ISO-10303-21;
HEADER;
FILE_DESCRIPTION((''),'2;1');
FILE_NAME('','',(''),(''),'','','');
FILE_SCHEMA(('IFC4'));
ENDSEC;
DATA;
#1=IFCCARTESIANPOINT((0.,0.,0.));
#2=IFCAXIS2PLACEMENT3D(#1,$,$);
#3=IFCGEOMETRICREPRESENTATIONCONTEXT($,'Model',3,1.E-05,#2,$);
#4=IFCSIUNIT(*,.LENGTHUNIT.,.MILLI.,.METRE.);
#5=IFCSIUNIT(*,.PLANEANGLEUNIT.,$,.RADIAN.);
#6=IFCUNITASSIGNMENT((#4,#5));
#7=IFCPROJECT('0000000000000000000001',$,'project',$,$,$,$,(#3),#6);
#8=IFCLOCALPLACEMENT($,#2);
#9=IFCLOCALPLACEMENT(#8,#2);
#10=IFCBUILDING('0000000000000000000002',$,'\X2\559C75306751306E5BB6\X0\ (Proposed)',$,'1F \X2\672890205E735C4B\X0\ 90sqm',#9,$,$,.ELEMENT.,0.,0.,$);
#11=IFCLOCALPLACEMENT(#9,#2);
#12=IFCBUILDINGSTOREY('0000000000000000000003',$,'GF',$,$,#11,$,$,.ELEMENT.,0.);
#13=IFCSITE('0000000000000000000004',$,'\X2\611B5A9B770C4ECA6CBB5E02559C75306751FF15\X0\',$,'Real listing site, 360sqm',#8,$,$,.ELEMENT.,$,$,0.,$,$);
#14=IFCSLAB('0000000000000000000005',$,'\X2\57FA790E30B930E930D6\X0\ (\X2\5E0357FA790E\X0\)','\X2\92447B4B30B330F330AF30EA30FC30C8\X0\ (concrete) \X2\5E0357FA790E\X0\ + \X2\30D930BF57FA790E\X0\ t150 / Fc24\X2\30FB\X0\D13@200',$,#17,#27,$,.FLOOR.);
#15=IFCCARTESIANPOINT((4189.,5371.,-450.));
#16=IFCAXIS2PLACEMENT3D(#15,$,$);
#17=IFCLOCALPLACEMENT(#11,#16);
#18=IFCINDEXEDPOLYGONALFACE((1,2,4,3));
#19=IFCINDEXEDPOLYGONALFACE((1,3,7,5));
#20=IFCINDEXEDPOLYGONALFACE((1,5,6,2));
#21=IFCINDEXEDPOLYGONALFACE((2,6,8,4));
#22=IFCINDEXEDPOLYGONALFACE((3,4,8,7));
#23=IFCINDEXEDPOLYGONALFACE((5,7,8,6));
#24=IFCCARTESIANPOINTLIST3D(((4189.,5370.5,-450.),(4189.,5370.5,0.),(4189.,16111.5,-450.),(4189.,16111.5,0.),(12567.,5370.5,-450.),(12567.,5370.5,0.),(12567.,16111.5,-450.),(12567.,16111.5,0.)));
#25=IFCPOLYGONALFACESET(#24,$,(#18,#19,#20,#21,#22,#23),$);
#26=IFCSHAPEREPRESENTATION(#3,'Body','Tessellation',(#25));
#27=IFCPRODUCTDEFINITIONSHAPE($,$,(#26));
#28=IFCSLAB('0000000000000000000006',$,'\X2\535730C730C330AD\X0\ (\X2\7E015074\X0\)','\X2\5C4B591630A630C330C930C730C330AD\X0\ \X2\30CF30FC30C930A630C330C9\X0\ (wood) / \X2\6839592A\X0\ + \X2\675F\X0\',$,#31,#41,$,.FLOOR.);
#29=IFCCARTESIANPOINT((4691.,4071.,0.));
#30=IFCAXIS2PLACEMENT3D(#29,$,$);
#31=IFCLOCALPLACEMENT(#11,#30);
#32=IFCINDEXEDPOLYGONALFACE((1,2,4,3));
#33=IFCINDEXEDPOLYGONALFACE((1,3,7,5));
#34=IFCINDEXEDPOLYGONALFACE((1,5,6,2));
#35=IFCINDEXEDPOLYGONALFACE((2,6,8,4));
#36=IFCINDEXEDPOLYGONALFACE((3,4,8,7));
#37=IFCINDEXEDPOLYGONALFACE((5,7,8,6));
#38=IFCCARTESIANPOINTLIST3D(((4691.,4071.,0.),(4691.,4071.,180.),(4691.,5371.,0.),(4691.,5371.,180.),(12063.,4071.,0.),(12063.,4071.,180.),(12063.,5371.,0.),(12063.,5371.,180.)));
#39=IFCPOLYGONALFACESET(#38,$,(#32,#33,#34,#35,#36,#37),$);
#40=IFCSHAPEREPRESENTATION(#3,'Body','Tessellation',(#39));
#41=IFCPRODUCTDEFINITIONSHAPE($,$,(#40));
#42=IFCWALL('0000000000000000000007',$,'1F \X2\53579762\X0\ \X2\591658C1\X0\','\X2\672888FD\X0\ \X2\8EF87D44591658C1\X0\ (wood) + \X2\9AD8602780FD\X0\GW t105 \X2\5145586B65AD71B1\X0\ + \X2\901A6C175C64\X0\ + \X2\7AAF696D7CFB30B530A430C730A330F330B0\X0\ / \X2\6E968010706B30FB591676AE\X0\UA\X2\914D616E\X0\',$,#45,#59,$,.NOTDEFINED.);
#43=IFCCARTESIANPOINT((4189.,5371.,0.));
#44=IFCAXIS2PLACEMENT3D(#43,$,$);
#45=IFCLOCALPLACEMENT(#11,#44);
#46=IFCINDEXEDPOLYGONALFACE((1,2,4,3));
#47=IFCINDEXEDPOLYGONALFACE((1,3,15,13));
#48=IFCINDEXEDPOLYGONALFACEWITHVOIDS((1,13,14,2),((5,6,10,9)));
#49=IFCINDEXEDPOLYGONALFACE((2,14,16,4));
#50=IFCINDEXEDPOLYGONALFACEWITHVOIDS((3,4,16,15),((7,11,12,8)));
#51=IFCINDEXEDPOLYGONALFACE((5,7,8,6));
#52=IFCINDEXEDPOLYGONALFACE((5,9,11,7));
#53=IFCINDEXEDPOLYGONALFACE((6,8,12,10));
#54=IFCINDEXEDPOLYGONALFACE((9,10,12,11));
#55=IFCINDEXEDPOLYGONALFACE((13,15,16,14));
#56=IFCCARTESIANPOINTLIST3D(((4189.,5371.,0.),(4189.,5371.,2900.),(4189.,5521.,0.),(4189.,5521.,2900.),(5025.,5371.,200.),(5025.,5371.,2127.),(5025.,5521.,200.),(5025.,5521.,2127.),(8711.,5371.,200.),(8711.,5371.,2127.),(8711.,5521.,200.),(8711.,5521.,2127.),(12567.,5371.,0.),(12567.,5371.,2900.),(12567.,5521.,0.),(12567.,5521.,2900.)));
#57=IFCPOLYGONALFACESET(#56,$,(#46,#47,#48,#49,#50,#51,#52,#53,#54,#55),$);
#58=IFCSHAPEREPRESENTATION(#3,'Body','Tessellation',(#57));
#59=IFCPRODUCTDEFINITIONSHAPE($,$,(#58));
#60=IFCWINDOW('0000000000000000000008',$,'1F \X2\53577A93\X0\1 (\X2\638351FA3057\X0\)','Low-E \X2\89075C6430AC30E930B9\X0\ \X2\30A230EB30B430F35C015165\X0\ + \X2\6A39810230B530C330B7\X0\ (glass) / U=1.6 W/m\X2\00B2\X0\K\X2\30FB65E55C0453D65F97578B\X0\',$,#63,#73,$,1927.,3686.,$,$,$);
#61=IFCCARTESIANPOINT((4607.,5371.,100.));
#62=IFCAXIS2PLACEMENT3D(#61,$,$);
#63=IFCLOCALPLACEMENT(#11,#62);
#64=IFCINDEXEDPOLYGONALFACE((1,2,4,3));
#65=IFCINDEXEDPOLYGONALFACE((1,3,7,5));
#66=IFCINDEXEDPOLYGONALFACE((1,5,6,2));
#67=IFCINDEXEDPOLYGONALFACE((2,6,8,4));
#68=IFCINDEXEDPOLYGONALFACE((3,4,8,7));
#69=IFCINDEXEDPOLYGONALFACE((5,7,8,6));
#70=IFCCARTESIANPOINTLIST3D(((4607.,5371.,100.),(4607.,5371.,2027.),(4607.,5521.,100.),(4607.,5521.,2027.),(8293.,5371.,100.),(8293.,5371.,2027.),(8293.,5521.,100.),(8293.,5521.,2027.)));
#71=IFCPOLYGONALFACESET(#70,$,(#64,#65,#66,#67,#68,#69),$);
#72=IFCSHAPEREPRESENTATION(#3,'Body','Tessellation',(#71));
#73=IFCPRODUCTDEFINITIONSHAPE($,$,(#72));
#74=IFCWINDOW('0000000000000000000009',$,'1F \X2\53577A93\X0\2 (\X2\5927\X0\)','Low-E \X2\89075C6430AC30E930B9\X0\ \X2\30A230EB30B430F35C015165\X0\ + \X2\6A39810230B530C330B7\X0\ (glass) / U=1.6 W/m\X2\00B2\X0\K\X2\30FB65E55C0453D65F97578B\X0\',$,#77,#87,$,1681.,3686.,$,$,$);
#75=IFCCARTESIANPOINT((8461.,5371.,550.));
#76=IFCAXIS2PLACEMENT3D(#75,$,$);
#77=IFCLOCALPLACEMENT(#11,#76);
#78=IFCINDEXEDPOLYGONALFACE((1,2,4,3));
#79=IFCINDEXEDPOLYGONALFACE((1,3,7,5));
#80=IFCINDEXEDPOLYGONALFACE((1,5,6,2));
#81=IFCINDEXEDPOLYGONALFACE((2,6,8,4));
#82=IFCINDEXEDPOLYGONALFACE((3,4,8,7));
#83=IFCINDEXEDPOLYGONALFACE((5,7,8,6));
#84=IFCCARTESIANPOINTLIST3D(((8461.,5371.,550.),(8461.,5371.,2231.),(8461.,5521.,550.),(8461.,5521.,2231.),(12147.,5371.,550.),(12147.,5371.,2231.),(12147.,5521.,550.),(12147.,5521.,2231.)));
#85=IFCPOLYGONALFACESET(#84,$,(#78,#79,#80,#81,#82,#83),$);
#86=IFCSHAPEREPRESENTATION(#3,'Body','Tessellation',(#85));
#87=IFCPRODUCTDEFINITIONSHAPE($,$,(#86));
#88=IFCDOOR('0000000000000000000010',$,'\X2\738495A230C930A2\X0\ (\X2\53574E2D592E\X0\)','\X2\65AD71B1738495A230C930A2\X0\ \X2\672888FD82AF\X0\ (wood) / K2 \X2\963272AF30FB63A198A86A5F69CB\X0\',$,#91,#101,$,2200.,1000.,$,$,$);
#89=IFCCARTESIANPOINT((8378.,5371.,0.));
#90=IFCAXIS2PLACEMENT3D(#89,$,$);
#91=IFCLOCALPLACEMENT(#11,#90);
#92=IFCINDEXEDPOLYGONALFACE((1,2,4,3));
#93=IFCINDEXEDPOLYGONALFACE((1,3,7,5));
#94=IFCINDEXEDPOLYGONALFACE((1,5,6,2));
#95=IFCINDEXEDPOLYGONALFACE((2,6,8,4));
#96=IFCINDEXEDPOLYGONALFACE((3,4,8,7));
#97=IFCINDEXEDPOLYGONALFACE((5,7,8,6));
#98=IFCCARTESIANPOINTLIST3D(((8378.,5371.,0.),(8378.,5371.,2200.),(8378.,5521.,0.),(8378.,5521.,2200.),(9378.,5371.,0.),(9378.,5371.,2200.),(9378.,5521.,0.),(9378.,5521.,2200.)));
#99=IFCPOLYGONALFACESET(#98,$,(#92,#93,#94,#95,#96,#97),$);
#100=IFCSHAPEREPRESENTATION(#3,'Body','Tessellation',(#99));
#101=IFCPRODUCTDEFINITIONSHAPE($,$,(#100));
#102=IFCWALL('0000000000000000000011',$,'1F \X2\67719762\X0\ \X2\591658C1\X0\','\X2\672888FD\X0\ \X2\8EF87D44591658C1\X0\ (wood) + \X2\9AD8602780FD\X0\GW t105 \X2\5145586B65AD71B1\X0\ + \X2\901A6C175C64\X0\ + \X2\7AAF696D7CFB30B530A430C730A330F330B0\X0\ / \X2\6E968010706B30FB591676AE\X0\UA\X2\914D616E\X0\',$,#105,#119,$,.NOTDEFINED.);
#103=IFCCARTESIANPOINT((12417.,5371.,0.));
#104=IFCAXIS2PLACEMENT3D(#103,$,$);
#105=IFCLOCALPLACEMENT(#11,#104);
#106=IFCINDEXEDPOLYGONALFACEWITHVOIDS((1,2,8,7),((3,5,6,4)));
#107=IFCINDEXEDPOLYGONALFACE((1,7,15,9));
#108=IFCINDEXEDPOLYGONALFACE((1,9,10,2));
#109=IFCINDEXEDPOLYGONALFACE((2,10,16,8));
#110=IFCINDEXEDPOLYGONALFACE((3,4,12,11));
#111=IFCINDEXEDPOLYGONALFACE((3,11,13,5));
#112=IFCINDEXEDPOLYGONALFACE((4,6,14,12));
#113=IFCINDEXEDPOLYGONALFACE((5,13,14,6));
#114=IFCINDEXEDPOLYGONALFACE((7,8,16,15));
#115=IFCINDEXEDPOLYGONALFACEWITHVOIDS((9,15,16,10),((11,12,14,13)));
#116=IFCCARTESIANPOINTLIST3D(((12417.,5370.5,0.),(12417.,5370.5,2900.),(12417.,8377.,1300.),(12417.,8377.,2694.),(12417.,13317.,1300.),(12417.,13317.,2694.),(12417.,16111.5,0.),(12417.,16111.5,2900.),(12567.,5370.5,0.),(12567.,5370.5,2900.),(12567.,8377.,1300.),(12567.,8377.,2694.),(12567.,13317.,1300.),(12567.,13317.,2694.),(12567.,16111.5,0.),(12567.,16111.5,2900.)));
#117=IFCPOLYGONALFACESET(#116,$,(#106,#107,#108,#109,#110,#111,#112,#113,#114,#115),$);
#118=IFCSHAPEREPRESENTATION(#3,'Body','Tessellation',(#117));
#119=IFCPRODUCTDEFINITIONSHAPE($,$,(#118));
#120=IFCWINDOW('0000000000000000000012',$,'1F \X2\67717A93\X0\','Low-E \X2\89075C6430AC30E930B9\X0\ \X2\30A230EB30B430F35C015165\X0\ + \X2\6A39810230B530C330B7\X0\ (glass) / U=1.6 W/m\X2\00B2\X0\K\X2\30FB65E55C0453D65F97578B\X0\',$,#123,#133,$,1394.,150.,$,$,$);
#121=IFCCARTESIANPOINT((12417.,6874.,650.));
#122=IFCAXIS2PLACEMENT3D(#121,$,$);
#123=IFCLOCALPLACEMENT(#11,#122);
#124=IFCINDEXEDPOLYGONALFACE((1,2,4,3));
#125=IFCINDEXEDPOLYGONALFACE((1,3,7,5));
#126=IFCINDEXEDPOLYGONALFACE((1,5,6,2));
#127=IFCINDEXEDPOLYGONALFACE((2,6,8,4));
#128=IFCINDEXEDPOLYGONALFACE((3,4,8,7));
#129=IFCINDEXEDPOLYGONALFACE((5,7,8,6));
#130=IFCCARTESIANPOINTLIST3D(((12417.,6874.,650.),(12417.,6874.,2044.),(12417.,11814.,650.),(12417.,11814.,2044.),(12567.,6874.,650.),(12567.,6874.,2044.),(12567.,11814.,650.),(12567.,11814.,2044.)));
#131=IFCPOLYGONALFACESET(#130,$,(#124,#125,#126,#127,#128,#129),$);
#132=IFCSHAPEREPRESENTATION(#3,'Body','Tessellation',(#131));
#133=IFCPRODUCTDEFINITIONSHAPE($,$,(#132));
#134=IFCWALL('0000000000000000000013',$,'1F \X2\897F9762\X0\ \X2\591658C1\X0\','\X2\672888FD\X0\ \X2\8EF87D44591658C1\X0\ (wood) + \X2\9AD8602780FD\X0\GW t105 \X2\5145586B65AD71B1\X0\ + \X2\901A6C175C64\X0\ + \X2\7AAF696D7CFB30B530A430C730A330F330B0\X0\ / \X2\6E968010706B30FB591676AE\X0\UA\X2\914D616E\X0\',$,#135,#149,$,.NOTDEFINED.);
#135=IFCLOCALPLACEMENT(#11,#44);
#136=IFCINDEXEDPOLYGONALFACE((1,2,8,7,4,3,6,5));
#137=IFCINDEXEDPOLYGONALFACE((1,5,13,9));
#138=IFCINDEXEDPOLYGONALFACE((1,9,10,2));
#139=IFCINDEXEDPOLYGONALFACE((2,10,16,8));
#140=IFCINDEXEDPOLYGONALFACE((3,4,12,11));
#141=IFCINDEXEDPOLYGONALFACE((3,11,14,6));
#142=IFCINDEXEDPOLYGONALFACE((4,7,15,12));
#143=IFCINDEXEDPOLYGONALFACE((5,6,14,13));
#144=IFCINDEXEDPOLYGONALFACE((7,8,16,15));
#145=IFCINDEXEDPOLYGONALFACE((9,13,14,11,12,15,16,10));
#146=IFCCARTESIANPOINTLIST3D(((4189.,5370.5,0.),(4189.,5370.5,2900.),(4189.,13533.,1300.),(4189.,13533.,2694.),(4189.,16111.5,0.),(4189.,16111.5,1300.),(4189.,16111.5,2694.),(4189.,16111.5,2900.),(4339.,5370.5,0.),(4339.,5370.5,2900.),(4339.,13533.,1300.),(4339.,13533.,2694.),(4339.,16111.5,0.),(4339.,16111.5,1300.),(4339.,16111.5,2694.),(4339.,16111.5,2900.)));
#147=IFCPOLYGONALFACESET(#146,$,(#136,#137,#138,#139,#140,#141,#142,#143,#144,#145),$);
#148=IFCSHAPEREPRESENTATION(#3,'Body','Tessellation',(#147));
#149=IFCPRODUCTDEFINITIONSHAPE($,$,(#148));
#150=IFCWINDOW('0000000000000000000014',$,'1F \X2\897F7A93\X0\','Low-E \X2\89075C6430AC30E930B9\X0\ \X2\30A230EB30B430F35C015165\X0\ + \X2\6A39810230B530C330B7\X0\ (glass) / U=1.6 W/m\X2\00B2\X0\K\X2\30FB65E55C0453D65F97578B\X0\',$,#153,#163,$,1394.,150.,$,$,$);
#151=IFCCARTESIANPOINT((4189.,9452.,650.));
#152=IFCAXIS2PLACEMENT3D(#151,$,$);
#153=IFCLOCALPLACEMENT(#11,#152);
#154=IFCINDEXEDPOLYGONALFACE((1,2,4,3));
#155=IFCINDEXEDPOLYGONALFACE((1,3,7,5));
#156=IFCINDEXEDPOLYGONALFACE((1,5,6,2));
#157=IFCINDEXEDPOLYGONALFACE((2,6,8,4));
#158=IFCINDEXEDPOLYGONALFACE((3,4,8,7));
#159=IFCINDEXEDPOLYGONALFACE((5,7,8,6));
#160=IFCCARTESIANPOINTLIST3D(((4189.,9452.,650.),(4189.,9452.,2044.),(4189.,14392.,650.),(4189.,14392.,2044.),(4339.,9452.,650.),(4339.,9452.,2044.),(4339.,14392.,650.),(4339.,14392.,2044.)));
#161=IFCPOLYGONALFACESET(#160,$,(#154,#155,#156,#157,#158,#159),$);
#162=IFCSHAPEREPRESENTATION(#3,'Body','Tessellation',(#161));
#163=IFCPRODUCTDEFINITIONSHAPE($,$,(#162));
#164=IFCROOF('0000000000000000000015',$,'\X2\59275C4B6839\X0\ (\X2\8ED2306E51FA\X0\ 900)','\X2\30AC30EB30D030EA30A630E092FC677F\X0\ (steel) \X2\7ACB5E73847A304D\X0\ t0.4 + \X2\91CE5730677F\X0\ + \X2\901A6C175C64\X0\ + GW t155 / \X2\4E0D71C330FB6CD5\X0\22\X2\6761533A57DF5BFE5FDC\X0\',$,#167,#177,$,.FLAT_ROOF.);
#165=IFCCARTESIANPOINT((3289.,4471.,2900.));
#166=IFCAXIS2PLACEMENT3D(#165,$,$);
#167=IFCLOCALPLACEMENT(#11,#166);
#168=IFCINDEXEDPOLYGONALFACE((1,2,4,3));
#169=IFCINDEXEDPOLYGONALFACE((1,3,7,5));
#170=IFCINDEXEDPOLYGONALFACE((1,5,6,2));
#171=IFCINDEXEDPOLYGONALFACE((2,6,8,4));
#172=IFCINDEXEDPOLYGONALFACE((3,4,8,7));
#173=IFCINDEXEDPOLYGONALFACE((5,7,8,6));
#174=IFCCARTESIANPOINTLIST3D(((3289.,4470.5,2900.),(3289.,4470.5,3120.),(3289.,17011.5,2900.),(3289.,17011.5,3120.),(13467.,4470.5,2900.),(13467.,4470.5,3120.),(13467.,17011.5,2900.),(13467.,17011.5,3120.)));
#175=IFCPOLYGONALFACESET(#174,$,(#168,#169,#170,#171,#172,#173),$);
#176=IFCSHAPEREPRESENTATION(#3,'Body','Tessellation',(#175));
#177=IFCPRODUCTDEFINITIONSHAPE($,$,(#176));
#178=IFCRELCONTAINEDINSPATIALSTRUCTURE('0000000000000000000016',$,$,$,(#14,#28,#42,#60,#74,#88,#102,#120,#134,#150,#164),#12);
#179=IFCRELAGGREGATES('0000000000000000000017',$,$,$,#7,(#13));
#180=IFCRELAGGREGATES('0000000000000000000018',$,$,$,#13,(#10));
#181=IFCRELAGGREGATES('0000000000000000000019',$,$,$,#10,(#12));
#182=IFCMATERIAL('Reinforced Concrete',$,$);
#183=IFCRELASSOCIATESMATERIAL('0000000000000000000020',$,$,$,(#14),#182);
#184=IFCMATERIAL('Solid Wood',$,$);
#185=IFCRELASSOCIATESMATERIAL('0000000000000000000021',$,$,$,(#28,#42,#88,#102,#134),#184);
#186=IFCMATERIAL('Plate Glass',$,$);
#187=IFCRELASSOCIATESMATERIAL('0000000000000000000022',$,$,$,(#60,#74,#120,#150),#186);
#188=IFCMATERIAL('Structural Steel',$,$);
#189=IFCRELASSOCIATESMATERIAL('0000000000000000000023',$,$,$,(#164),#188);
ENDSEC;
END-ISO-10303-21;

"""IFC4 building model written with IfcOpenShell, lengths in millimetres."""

from ifc_helpers import new_model, si_unit, frame, frame_2d, origin, place, context, project, spatial, rectangle, extrude, material, element, fill, save


model = new_model("IFC4")

# Units and contexts
model_context = context("Model", 3, precision=1e-05, world=origin())
ifc_project = project(units=[si_unit("LENGTHUNIT", "METRE", prefix="MILLI"), si_unit("PLANEANGLEUNIT", "RADIAN")], contexts=[model_context])

# Site, building, storey
site_placement = place(None, origin())
site = spatial("IfcSite", under=ifc_project, at=site_placement, Name="愛媛県今治市喜田村５", ObjectType="Real listing site, 360sqm", CompositionType="ELEMENT", RefElevation=0.0)
building_placement = place(site_placement, origin())
building = spatial("IfcBuilding", under=site, at=building_placement, Name="喜田村の家 (Proposed)", ObjectType="1F 木造平屋 90sqm", CompositionType="ELEMENT", ElevationOfRefHeight=0.0, ElevationOfTerrain=0.0)
storey_placement = place(building_placement, origin())
storey = spatial("IfcBuildingStorey", under=building, at=storey_placement, Name="GF", CompositionType="ELEMENT", Elevation=0.0)

# Slabs
ifc_material_1 = material(Name="Reinforced Concrete")
slab_1_placement = place(storey_placement, frame((4189.0, 5371.0, -450.0)))
element("IfcSlab", 1, at=slab_1_placement, inside=storey, material=ifc_material_1, Name="基礎スラブ (布基礎)", Description="鉄筋コンクリート (concrete) 布基礎 + ベタ基礎 t150 / Fc24・D13@200", PredefinedType="FLOOR", context=model_context, shape_type="SweptSolid", body=[
    extrude(rectangle(XDim=8378.0, YDim=10741.0, at=frame_2d((4189.0, 5370.0))), frame((4189.0, 5371.0, -450.0)), (0.0, 0.0, 1.0), 450.0),
])
ifc_material_2 = material(Name="Solid Wood")
slab_2_placement = place(storey_placement, frame((4691.0, 4071.0, 0.0)))
element("IfcSlab", 2, at=slab_2_placement, inside=storey, material=ifc_material_2, Name="南デッキ (縁側)", Description="屋外ウッドデッキ ハードウッド (wood) / 根太 + 束", PredefinedType="FLOOR", context=model_context, shape_type="SweptSolid", body=[
    extrude(rectangle(XDim=7372.0, YDim=1300.0, at=frame_2d((3686.0, 650.0))), frame((4691.0, 4071.0, 0.0)), (0.0, 0.0, 1.0), 180.0),
])

# Wall, openings, windows, door
wall_1_placement = place(storey_placement, frame((4189.0, 5371.0, 0.0)))
wall_1 = element("IfcWall", 3, at=wall_1_placement, inside=storey, material=ifc_material_2, Name="1F 南面 外壁", Description="木製 軸組外壁 (wood) + 高性能GW t105 充填断熱 + 通気層 + 窯業系サイディング / 準耐火・外皮UA配慮", PredefinedType="NOTDEFINED", context=model_context, shape_type="SweptSolid", body=[
    extrude(rectangle(XDim=8378.0, YDim=150.0, at=frame_2d((4189.0, 75.0))), frame((4189.0, 5371.0, 0.0)), (0.0, 0.0, 1.0), 2900.0),
])
opening_1_placement = place(storey_placement, frame((4607.0, 5371.0, 100.0)))
opening_1 = element("IfcOpeningElement", 4, at=opening_1_placement, cuts=wall_1, PredefinedType="NOTDEFINED", context=model_context, shape_type="SweptSolid", body=[
    extrude(rectangle(XDim=3686.0, YDim=150.0, at=frame_2d((1843.0, 75.0))), frame((4607.0, 5371.0, 100.0)), (0.0, 0.0, 1.0), 1927.0),
])
opening_2_placement = place(storey_placement, frame((8461.0, 5371.0, 550.0)))
opening_2 = element("IfcOpeningElement", 5, at=opening_2_placement, cuts=wall_1, PredefinedType="NOTDEFINED", context=model_context, shape_type="SweptSolid", body=[
    extrude(rectangle(XDim=3686.0, YDim=150.0, at=frame_2d((1843.0, 75.0))), frame((8461.0, 5371.0, 550.0)), (0.0, 0.0, 1.0), 1681.0),
])
opening_3_placement = place(storey_placement, frame((8378.0, 5371.0, 0.0)))
opening_3 = element("IfcOpeningElement", 6, at=opening_3_placement, cuts=wall_1, PredefinedType="NOTDEFINED", context=model_context, shape_type="SweptSolid", body=[
    extrude(rectangle(XDim=1000.0, YDim=150.0, at=frame_2d((500.0, 75.0))), frame((8378.0, 5371.0, 0.0)), (0.0, 0.0, 1.0), 2200.0),
])
ifc_material_3 = material(Name="Plate Glass")
window_1_placement = place(storey_placement, frame((4607.0, 5371.0, 100.0)))
window_1 = element("IfcWindow", 7, at=window_1_placement, inside=storey, material=ifc_material_3, Name="1F 南窓1 (掃出し)", Description="Low-E 複層ガラス アルゴン封入 + 樹脂サッシ (glass) / U=1.6 W/m²K・日射取得型", OverallHeight=1927.0, OverallWidth=3686.0, context=model_context, shape_type="SweptSolid", body=[
    extrude(rectangle(XDim=3686.0, YDim=150.0, at=frame_2d((1843.0, 75.0))), frame((4607.0, 5371.0, 100.0)), (0.0, 0.0, 1.0), 1927.0),
])
fill(opening_1, window_1)
window_2_placement = place(storey_placement, frame((8461.0, 5371.0, 550.0)))
window_2 = element("IfcWindow", 8, at=window_2_placement, inside=storey, material=ifc_material_3, Name="1F 南窓2 (大)", Description="Low-E 複層ガラス アルゴン封入 + 樹脂サッシ (glass) / U=1.6 W/m²K・日射取得型", OverallHeight=1681.0, OverallWidth=3686.0, context=model_context, shape_type="SweptSolid", body=[
    extrude(rectangle(XDim=3686.0, YDim=150.0, at=frame_2d((1843.0, 75.0))), frame((8461.0, 5371.0, 550.0)), (0.0, 0.0, 1.0), 1681.0),
])
fill(opening_2, window_2)
door_placement = place(storey_placement, frame((8378.0, 5371.0, 0.0)))
door = element("IfcDoor", 9, at=door_placement, inside=storey, material=ifc_material_2, Name="玄関ドア (南中央)", Description="断熱玄関ドア 木製芯 (wood) / K2 防犯・採風機構", OverallHeight=2200.0, OverallWidth=1000.0, context=model_context, shape_type="SweptSolid", body=[
    extrude(rectangle(XDim=1000.0, YDim=150.0, at=frame_2d((500.0, 75.0))), frame((8378.0, 5371.0, 0.0)), (0.0, 0.0, 1.0), 2200.0),
])
fill(opening_3, door)

# Walls, openings, windows
wall_2_placement = place(storey_placement, frame((12417.0, 5371.0, 0.0)))
wall_2 = element("IfcWall", 10, at=wall_2_placement, inside=storey, material=ifc_material_2, Name="1F 東面 外壁", Description="木製 軸組外壁 (wood) + 高性能GW t105 充填断熱 + 通気層 + 窯業系サイディング / 準耐火・外皮UA配慮", PredefinedType="NOTDEFINED", context=model_context, shape_type="SweptSolid", body=[
    extrude(rectangle(XDim=150.0, YDim=10741.0, at=frame_2d((75.0, 5370.0))), frame((12417.0, 5371.0, 0.0)), (0.0, 0.0, 1.0), 2900.0),
])
opening_4_placement = place(storey_placement, frame((12417.0, 6874.0, 650.0)))
opening_4 = element("IfcOpeningElement", 11, at=opening_4_placement, cuts=wall_2, PredefinedType="NOTDEFINED", context=model_context, shape_type="SweptSolid", body=[
    extrude(rectangle(XDim=150.0, YDim=4940.0, at=frame_2d((75.0, 2470.0))), frame((12417.0, 6874.0, 650.0)), (0.0, 0.0, 1.0), 1394.0),
])
window_3_placement = place(storey_placement, frame((12417.0, 6874.0, 650.0)))
window_3 = element("IfcWindow", 12, at=window_3_placement, inside=storey, material=ifc_material_3, Name="1F 東窓", Description="Low-E 複層ガラス アルゴン封入 + 樹脂サッシ (glass) / U=1.6 W/m²K・日射取得型", OverallHeight=1394.0, OverallWidth=150.0, context=model_context, shape_type="SweptSolid", body=[
    extrude(rectangle(XDim=150.0, YDim=4940.0, at=frame_2d((75.0, 2470.0))), frame((12417.0, 6874.0, 650.0)), (0.0, 0.0, 1.0), 1394.0),
])
fill(opening_4, window_3)
wall_3_placement = place(storey_placement, frame((4189.0, 5371.0, 0.0)))
wall_3 = element("IfcWall", 13, at=wall_3_placement, inside=storey, material=ifc_material_2, Name="1F 西面 外壁", Description="木製 軸組外壁 (wood) + 高性能GW t105 充填断熱 + 通気層 + 窯業系サイディング / 準耐火・外皮UA配慮", PredefinedType="NOTDEFINED", context=model_context, shape_type="SweptSolid", body=[
    extrude(rectangle(XDim=150.0, YDim=10741.0, at=frame_2d((75.0, 5370.0))), frame((4189.0, 5371.0, 0.0)), (0.0, 0.0, 1.0), 2900.0),
])
opening_5_placement = place(storey_placement, frame((4189.0, 9452.0, 650.0)))
opening_5 = element("IfcOpeningElement", 14, at=opening_5_placement, cuts=wall_3, PredefinedType="NOTDEFINED", context=model_context, shape_type="SweptSolid", body=[
    extrude(rectangle(XDim=150.0, YDim=4940.0, at=frame_2d((75.0, 2470.0))), frame((4189.0, 9452.0, 650.0)), (0.0, 0.0, 1.0), 1394.0),
])
window_4_placement = place(storey_placement, frame((4189.0, 9452.0, 650.0)))
window_4 = element("IfcWindow", 15, at=window_4_placement, inside=storey, material=ifc_material_3, Name="1F 西窓", Description="Low-E 複層ガラス アルゴン封入 + 樹脂サッシ (glass) / U=1.6 W/m²K・日射取得型", OverallHeight=1394.0, OverallWidth=150.0, context=model_context, shape_type="SweptSolid", body=[
    extrude(rectangle(XDim=150.0, YDim=4940.0, at=frame_2d((75.0, 2470.0))), frame((4189.0, 9452.0, 650.0)), (0.0, 0.0, 1.0), 1394.0),
])
fill(opening_5, window_4)

# Roof
ifc_material_4 = material(Name="Structural Steel")
roof_placement = place(storey_placement, frame((3289.0, 4471.0, 2900.0)))
element("IfcRoof", 16, at=roof_placement, inside=storey, material=ifc_material_4, Name="大屋根 (軒の出 900)", Description="ガルバリウム鋼板 (steel) 立平葺き t0.4 + 野地板 + 通気層 + GW t155 / 不燃・法22条区域対応", PredefinedType="FLAT_ROOF", context=model_context, shape_type="SweptSolid", body=[
    extrude(rectangle(XDim=10178.0, YDim=12541.0, at=frame_2d((5089.0, 6270.0))), frame((3289.0, 4471.0, 2900.0)), (0.0, 0.0, 1.0), 220.0),
])

save(model, "model.ifc")
